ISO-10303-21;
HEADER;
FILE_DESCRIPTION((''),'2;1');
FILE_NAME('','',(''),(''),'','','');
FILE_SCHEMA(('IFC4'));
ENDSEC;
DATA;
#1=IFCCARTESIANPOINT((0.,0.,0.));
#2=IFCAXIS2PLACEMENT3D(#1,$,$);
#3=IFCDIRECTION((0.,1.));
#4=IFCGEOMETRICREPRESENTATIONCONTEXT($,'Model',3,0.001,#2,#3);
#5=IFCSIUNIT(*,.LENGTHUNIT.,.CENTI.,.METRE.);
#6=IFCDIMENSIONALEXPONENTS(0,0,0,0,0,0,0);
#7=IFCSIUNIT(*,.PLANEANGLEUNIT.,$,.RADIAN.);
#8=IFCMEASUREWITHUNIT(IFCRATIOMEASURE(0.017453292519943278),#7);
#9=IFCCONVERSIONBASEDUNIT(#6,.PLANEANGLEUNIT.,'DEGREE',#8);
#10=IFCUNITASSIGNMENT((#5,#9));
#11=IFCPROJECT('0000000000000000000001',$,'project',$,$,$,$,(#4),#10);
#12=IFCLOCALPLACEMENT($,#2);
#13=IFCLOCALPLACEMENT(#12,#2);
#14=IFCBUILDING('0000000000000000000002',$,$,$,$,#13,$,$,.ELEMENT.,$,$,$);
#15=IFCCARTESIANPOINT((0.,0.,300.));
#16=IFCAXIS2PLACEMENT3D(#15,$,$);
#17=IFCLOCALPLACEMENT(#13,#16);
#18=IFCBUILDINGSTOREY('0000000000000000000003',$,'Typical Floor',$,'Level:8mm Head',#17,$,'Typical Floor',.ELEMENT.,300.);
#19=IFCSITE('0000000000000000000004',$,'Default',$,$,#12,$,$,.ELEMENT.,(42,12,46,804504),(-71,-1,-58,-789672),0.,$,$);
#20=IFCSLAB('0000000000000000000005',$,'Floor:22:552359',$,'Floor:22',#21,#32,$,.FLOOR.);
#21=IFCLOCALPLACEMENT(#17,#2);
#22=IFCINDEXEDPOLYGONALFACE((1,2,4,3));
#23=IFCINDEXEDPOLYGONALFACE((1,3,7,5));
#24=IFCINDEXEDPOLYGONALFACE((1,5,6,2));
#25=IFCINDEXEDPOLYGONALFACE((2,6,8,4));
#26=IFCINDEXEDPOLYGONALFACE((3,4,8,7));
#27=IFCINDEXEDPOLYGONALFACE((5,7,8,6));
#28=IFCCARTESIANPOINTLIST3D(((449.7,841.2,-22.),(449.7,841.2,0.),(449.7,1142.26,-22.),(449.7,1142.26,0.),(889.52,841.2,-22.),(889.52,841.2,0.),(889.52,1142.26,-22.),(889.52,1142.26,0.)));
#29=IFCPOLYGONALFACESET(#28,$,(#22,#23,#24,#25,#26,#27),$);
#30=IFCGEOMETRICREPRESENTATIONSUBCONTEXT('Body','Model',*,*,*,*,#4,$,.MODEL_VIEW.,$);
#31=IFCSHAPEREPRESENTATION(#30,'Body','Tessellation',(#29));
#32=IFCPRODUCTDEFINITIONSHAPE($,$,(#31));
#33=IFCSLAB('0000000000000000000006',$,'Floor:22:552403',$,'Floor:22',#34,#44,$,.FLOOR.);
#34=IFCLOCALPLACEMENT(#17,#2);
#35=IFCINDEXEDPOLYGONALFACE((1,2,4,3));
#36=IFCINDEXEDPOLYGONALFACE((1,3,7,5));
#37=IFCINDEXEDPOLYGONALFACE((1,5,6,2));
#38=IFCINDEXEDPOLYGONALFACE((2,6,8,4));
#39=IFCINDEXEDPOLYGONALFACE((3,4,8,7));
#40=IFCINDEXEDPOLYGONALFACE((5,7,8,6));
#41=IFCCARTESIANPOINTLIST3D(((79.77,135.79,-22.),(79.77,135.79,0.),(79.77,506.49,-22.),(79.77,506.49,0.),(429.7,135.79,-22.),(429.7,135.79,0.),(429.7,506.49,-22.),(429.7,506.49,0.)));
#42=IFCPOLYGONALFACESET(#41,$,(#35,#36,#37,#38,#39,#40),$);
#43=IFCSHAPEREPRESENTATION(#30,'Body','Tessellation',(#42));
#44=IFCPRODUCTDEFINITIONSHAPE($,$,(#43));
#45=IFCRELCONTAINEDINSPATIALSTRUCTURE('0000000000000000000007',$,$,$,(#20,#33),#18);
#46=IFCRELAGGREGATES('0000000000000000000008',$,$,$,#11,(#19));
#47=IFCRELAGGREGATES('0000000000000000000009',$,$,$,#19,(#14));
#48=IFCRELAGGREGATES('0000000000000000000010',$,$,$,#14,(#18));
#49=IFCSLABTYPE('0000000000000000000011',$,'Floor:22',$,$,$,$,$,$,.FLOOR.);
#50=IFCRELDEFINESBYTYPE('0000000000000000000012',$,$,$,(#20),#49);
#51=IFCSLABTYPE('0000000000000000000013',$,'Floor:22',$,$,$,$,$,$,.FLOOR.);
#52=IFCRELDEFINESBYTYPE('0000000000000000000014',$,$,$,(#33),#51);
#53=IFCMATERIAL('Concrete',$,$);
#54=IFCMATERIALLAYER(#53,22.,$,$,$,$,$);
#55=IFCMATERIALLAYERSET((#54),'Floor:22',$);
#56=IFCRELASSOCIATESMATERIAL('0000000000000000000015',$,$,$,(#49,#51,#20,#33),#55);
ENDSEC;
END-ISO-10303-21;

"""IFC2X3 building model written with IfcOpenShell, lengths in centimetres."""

from ifc_helpers import new_model, entity, si_unit, converted_unit, direction, frame, frame_2d, origin, origin_2d_with_axis, place, context, subcontext, project, spatial, rectangle, extrude, material, layer, layer_set, layer_usage, type_object, element, save


model = new_model("IFC2X3")

# Units and contexts
model_context = context("Model", 3, precision=0.001, world=origin(), true_north=direction((0.0, 1.0)))
body_context = subcontext(model_context, "Body", "Model", "MODEL_VIEW")
ifc_project = project(units=[si_unit("LENGTHUNIT", "METRE", prefix="CENTI"), converted_unit("PLANEANGLEUNIT", "DEGREE", entity("IfcRatioMeasure", 0.017453292519943278), si_unit("PLANEANGLEUNIT", "RADIAN"), dimensions=[0, 0, 0, 0, 0, 0, 0])], contexts=[model_context])

# Site, building, storey
site_placement = place(None, origin())
site = spatial("IfcSite", under=ifc_project, at=site_placement, Name="Default", CompositionType="ELEMENT", RefLatitude=(42, 12, 46, 804504), RefLongitude=(-71, -1, -58, -789672), RefElevation=0.0)
building_placement = place(site_placement, origin())
building = spatial("IfcBuilding", under=site, at=building_placement, CompositionType="ELEMENT")
storey_placement = place(building_placement, frame((0.0, 0.0, 300.0)))
storey = spatial("IfcBuildingStorey", under=building, at=storey_placement, Name="Typical Floor", ObjectType="Level:8mm Head", LongName="Typical Floor", CompositionType="ELEMENT", Elevation=300.0)

# Shared definitions
ifc_material = material(Name="Concrete")

# Slabs
ifc_layer = layer(ifc_material, 22.0)
ifc_layer_set = layer_set([ifc_layer], Name="Floor:22")
ifc_layer_usage_1 = layer_usage(ifc_layer_set, "AXIS3", "POSITIVE", 0.0)
slab_type_1 = type_object("IfcSlabType", Name="Floor:22", PredefinedType="FLOOR", material=ifc_layer_set)
slab_1_placement = place(storey_placement, origin())
element("IfcSlab", 1, at=slab_1_placement, inside=storey, type_object=slab_type_1, material=ifc_layer_usage_1, Name="Floor:22:552359", ObjectType="Floor:22", PredefinedType="FLOOR", context=body_context, shape_type="SweptSolid", body=[
    extrude(rectangle(XDim=301.06, YDim=439.81, at=frame_2d((0.0, 0.0), x_axis=(1.0, 0.0))), frame((669.61, 991.73, 0.0), z_axis=(0.0, 0.0, -1.0), x_axis=(0.0, 1.0, 0.0)), (0.0, 0.0, 1.0), 22.0),
])
ifc_layer_usage_2 = layer_usage(ifc_layer_set, "AXIS3", "POSITIVE", 0.0)
slab_type_2 = type_object("IfcSlabType", Name="Floor:22", PredefinedType="FLOOR", material=ifc_layer_set)
slab_2_placement = place(storey_placement, origin())
element("IfcSlab", 2, at=slab_2_placement, inside=storey, type_object=slab_type_2, material=ifc_layer_usage_2, Name="Floor:22:552403", ObjectType="Floor:22", PredefinedType="FLOOR", context=body_context, shape_type="SweptSolid", body=[
    extrude(rectangle(XDim=370.7, YDim=349.94, at=origin_2d_with_axis()), frame((254.74, 321.14, 0.0), z_axis=(0.0, 0.0, -1.0), x_axis=(0.0, 1.0, 0.0)), (0.0, 0.0, 1.0), 22.0),
])

save(model, "model.ifc")
